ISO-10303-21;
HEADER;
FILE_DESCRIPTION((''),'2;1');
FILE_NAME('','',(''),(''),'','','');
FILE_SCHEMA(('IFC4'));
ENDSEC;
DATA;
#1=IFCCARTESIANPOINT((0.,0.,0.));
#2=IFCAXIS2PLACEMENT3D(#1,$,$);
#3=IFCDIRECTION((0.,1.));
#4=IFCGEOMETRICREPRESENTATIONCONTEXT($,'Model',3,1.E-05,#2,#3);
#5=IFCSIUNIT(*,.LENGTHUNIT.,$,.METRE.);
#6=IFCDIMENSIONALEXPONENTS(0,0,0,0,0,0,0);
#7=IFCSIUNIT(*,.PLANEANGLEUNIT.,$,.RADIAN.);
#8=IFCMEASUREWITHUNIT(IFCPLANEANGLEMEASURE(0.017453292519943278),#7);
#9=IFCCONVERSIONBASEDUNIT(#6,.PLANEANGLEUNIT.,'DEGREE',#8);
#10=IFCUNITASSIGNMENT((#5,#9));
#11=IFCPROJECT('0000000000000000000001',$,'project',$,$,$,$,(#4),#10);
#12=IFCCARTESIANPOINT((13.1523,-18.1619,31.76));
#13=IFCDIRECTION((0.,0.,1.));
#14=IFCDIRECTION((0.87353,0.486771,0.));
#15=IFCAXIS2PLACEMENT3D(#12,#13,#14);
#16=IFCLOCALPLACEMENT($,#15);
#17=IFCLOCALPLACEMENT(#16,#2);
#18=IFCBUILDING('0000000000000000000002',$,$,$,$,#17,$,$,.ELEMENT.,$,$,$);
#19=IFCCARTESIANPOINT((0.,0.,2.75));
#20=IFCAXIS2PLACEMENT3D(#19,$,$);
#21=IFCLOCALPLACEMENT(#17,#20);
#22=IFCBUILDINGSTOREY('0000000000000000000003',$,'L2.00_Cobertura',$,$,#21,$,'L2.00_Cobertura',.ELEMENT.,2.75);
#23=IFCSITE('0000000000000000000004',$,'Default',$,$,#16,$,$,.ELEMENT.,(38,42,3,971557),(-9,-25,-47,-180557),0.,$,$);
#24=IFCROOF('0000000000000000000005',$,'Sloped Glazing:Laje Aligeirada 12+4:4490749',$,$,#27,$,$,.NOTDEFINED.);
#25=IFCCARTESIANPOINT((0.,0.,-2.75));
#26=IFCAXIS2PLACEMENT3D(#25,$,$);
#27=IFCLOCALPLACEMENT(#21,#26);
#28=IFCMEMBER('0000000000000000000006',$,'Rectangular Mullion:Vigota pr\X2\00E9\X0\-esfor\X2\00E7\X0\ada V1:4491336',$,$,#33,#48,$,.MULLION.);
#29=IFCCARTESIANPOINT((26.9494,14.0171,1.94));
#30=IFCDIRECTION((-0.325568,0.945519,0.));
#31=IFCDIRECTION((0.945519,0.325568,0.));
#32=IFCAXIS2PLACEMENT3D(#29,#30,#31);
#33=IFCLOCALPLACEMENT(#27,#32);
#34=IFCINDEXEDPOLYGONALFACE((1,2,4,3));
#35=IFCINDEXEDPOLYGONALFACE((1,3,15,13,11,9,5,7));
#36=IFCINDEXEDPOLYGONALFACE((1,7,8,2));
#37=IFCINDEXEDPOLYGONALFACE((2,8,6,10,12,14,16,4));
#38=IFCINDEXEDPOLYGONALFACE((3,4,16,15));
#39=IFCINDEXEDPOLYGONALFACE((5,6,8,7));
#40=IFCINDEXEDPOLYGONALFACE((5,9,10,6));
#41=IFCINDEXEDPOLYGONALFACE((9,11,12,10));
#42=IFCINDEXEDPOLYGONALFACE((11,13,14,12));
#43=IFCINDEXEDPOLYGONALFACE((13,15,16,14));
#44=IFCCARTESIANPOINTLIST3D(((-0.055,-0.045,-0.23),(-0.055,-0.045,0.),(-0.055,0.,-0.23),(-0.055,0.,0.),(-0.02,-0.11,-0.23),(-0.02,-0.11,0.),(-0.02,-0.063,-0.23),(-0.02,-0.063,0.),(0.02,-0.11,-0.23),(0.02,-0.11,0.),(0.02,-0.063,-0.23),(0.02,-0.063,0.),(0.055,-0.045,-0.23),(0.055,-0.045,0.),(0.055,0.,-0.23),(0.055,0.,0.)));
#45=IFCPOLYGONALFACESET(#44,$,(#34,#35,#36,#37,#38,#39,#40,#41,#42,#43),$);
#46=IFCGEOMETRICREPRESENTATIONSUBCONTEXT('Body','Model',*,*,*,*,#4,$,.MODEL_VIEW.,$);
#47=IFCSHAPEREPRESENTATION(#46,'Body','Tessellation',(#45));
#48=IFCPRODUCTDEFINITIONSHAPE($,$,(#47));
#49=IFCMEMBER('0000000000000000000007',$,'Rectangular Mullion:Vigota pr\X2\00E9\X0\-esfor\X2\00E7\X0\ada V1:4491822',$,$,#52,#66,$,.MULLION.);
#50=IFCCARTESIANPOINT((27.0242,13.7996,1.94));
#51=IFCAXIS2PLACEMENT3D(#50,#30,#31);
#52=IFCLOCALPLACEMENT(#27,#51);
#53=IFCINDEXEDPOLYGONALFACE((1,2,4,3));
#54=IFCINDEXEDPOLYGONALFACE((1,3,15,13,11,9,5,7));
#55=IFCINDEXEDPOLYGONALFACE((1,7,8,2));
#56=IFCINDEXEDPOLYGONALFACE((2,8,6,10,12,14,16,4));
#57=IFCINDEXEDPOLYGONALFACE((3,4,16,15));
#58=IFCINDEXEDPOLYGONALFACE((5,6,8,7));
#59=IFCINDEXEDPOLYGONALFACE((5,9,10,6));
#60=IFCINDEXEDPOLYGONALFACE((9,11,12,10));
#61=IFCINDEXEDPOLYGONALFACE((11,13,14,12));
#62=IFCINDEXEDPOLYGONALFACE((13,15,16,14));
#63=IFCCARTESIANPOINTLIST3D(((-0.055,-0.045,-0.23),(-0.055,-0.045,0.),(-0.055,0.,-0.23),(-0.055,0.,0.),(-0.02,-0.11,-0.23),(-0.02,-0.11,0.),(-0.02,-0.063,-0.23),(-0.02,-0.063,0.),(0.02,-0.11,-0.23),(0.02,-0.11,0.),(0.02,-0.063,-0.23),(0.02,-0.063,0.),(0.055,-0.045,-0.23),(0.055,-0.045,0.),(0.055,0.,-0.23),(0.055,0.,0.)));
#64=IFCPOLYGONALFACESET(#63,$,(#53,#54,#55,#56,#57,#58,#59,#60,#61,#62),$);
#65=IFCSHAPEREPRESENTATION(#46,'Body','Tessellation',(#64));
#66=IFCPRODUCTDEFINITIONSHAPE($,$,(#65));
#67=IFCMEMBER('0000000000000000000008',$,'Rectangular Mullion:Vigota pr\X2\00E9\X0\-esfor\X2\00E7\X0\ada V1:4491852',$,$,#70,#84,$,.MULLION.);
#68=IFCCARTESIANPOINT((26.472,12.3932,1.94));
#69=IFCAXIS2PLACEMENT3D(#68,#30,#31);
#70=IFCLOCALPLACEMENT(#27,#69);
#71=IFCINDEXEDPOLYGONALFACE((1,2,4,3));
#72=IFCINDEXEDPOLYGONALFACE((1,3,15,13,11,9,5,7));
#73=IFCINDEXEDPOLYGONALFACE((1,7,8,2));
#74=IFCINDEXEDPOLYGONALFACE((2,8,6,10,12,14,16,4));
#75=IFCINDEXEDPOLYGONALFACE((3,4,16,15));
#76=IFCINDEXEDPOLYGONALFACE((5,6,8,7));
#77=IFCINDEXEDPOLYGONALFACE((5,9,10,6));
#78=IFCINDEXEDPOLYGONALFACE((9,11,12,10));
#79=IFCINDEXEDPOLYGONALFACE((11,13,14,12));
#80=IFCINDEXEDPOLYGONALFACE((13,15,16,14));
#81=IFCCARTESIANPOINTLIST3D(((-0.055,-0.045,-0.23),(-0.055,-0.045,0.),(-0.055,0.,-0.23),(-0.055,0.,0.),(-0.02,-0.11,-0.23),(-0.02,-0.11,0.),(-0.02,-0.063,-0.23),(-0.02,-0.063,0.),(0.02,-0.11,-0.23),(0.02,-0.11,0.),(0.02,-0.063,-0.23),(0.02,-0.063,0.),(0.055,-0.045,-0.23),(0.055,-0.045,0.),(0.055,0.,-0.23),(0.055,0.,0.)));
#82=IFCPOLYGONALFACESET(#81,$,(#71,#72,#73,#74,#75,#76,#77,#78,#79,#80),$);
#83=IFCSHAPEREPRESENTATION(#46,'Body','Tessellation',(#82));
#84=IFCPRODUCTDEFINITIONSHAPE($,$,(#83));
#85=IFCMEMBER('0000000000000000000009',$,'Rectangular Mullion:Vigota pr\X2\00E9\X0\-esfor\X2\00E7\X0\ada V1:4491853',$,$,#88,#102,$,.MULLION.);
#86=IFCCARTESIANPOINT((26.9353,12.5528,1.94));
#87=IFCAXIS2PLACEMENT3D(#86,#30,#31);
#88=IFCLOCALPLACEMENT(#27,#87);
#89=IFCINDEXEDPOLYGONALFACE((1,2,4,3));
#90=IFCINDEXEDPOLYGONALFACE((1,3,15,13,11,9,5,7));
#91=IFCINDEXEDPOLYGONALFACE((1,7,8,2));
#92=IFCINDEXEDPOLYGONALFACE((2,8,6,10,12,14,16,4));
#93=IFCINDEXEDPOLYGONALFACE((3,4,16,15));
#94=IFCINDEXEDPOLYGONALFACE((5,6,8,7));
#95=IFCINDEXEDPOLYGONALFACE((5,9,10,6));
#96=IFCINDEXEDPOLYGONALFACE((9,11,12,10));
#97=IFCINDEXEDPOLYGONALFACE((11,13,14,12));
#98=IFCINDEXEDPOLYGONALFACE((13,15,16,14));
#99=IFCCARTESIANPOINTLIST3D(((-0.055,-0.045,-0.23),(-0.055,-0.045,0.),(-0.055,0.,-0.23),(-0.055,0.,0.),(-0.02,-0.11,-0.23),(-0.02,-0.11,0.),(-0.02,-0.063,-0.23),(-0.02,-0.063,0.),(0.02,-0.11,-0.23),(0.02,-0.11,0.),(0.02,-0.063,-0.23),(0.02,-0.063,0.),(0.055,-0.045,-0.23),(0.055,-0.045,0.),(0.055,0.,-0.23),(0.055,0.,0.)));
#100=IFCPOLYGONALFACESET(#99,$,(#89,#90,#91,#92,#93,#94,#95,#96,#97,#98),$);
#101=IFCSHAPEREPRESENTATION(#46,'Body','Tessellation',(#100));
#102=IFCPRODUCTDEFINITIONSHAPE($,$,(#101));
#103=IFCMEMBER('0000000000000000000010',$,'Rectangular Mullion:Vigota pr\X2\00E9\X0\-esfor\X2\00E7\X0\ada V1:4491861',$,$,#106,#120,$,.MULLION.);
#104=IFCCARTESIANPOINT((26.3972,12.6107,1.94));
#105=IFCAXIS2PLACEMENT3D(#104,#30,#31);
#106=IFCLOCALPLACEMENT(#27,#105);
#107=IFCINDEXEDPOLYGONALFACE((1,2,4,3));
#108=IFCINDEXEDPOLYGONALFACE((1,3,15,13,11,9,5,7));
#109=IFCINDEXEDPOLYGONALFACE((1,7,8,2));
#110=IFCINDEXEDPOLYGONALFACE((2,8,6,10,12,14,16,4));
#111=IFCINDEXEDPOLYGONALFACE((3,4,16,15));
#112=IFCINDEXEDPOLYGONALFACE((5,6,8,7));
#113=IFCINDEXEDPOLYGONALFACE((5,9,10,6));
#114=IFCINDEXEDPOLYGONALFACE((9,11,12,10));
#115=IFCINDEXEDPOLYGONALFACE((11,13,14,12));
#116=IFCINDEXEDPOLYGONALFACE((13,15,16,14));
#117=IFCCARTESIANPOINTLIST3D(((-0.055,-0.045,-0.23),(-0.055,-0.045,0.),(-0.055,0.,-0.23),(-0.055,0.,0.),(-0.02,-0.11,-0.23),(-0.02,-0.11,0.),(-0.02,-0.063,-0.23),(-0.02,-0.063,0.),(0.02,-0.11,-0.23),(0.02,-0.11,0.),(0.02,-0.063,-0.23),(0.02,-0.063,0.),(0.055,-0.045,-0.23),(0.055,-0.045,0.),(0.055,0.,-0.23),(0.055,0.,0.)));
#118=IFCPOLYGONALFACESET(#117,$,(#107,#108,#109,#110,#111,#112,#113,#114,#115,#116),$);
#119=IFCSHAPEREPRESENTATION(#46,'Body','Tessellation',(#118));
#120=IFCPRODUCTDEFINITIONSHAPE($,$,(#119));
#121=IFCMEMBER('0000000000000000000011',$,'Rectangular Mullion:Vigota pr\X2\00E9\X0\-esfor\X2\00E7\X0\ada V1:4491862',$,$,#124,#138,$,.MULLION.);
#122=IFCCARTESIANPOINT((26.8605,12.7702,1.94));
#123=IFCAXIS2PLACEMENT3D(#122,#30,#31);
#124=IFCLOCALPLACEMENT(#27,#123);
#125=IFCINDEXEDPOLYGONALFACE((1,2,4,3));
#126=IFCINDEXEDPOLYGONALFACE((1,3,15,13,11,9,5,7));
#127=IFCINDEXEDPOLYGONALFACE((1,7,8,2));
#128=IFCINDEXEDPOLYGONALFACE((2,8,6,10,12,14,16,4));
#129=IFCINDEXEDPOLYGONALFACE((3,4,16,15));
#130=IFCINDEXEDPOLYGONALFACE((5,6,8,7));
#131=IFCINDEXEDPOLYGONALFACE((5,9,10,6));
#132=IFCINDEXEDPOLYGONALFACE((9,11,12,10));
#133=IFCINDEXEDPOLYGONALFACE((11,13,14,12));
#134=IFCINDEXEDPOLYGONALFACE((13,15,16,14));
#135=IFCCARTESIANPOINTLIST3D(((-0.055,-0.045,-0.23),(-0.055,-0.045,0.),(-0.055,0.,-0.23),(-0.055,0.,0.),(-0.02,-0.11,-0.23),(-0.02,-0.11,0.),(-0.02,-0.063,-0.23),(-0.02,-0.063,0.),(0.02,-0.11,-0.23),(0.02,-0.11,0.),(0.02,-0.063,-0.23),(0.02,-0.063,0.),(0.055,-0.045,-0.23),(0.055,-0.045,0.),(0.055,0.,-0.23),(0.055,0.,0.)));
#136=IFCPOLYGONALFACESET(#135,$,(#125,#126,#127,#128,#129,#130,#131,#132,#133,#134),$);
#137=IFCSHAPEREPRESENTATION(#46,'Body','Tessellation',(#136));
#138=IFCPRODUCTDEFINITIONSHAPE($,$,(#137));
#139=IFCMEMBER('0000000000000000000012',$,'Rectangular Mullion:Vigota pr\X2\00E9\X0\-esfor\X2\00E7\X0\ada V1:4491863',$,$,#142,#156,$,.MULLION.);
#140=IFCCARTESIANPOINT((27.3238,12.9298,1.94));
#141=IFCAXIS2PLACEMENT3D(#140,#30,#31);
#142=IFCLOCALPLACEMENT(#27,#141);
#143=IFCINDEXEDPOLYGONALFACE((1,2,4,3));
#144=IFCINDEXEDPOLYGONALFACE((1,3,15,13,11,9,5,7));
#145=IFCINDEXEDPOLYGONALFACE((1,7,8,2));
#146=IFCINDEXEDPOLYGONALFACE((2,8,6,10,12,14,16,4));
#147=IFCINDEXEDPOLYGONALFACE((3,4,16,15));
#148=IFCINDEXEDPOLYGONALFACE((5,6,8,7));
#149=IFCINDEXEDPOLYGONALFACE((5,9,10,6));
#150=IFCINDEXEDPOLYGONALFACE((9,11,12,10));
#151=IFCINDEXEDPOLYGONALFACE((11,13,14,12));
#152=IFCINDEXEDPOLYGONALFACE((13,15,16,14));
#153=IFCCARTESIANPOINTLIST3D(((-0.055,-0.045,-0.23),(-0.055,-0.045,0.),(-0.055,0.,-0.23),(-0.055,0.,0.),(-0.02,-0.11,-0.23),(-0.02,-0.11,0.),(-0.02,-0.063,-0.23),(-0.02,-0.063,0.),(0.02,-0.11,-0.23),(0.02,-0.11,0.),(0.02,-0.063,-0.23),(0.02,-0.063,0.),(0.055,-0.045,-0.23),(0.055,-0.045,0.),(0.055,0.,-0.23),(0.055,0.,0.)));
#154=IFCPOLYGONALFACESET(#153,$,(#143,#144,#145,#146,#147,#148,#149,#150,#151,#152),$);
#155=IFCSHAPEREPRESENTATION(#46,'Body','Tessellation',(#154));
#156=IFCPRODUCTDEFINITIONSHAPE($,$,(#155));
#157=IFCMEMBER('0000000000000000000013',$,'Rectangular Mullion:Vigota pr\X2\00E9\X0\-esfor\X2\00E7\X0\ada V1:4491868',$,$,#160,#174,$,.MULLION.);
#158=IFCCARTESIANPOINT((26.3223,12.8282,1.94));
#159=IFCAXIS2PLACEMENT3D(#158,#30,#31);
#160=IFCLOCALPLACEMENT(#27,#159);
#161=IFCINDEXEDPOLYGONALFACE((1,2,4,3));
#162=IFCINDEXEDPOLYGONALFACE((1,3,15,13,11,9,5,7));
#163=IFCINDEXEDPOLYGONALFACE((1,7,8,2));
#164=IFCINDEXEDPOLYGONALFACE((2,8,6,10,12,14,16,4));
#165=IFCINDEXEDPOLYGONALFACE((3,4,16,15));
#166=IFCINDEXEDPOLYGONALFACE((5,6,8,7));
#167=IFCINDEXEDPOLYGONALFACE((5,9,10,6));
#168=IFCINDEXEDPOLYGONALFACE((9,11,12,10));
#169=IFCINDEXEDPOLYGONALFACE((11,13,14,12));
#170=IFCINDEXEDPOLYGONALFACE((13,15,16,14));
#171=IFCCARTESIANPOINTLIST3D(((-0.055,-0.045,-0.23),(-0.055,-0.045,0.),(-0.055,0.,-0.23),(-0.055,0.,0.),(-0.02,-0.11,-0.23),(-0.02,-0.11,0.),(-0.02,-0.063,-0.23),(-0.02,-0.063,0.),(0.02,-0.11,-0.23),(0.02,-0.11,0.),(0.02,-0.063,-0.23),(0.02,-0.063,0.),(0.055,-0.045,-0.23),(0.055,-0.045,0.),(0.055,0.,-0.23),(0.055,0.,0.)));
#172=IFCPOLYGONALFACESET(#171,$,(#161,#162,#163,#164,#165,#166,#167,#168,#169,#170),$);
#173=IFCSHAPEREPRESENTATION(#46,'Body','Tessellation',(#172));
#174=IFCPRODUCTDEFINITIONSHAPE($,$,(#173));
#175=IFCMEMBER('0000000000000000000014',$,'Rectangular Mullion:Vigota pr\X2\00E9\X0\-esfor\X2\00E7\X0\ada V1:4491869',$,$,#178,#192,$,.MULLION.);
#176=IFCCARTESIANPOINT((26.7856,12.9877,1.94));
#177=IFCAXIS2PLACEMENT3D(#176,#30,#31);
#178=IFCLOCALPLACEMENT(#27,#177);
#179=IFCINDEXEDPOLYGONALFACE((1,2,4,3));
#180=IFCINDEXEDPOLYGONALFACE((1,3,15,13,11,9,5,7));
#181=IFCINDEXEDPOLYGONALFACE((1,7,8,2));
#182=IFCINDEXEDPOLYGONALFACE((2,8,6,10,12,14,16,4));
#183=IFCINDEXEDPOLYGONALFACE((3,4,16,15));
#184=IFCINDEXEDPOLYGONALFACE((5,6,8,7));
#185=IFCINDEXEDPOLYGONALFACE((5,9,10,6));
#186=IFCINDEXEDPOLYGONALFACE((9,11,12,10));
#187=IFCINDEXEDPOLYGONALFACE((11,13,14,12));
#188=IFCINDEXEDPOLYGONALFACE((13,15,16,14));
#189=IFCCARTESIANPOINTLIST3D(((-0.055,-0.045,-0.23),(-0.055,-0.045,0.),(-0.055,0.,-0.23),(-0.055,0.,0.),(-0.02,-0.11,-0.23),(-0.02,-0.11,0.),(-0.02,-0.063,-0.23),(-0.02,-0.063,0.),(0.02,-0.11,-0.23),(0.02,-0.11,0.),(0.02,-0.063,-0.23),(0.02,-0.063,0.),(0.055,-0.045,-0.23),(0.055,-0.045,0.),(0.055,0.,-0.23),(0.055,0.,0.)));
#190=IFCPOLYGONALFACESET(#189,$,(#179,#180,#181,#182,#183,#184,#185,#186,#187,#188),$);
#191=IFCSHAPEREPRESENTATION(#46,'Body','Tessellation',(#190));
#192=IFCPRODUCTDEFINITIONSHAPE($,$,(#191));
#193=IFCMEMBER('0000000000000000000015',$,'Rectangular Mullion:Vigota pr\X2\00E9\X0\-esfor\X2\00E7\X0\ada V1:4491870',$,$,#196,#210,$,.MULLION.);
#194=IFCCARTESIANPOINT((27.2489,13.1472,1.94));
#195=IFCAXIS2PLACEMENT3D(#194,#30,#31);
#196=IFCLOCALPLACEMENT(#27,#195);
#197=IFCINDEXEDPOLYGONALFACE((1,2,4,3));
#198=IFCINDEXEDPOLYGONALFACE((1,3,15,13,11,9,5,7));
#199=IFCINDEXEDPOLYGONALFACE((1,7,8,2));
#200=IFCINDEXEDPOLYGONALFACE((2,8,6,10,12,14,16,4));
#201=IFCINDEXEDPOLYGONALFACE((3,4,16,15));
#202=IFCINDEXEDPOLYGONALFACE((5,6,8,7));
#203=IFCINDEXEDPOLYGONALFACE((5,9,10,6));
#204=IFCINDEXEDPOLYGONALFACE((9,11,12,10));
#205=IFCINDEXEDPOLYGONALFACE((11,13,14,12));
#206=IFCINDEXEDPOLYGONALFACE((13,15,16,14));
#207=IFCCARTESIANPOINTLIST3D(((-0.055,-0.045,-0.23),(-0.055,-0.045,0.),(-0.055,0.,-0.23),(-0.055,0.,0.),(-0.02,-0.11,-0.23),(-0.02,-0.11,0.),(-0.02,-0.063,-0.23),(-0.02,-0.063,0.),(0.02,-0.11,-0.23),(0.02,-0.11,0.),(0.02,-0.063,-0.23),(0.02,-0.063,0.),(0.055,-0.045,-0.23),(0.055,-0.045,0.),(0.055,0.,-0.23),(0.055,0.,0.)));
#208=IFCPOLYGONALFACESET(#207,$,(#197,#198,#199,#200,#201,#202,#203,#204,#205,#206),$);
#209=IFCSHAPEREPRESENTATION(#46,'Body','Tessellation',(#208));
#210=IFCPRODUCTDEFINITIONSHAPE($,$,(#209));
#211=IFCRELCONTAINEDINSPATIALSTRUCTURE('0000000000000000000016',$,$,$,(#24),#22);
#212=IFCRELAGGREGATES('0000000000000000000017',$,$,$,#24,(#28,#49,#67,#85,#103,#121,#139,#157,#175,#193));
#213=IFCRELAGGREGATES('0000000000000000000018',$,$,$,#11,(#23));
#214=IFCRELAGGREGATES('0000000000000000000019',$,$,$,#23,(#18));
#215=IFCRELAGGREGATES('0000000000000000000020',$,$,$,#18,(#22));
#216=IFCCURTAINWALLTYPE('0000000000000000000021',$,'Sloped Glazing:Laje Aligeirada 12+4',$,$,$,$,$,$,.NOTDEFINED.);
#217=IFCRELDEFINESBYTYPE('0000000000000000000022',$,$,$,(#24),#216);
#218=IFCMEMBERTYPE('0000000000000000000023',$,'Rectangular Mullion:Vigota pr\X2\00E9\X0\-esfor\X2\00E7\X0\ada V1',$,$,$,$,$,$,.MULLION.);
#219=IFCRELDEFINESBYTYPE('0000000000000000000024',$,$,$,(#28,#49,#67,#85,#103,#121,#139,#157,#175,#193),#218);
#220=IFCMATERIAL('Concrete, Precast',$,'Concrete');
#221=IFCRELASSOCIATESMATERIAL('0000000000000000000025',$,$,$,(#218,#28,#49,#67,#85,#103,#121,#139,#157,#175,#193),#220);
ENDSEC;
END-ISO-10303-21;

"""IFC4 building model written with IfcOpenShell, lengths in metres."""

from ifc_helpers import new_model, entity, si_unit, converted_unit, direction, frame, origin, place, context, subcontext, project, spatial, indexed_curve, outline, extrude, source, transform, mapped, material, type_object, type_shapes, element, aggregate, save


model = new_model("IFC4")

# Units and contexts
model_context = context("Model", 3, precision=1e-05, world=origin(), true_north=direction((0.0, 1.0)))
body_context = subcontext(model_context, "Body", "Model", "MODEL_VIEW")
ifc_project = project(units=[si_unit("LENGTHUNIT", "METRE"), converted_unit("PLANEANGLEUNIT", "DEGREE", entity("IfcPlaneAngleMeasure", 0.017453292519943278), si_unit("PLANEANGLEUNIT", "RADIAN"), dimensions=[0, 0, 0, 0, 0, 0, 0])], contexts=[model_context])

# Site, building, storey
site_placement = place(None, frame((13.1523, -18.1619, 31.76), z_axis=(0.0, 0.0, 1.0), x_axis=(0.87353, 0.486771, 0.0)))
site = spatial("IfcSite", under=ifc_project, at=site_placement, Name="Default", CompositionType="ELEMENT", RefLatitude=(38, 42, 3, 971557), RefLongitude=(-9, -25, -47, -180557), RefElevation=0.0)
building_placement = place(site_placement, origin())
building = spatial("IfcBuilding", under=site, at=building_placement, CompositionType="ELEMENT")
storey_placement = place(building_placement, frame((0.0, 0.0, 2.75)))
storey = spatial("IfcBuildingStorey", under=building, at=storey_placement, Name="L2.00_Cobertura", LongName="L2.00_Cobertura", CompositionType="ELEMENT", Elevation=2.75)

# Roof, members
curtain_wall_type = type_object("IfcCurtainWallType", Name="Sloped Glazing:Laje Aligeirada 12+4", PredefinedType="NOTDEFINED")
roof_placement = place(storey_placement, frame((0.0, 0.0, -2.75)))
roof = element("IfcRoof", 1, at=roof_placement, inside=storey, type_object=curtain_wall_type, Name="Sloped Glazing:Laje Aligeirada 12+4:4490749", PredefinedType="NOTDEFINED")
ifc_material_1 = material(Name="Concrete, Precast", Category="Concrete")
member_type = type_object("IfcMemberType", Name="Rectangular Mullion:Vigota pré-esforçada V1", PredefinedType="MULLION", material=ifc_material_1)
shared_shape_1 = source(origin(), body_context, "Body", "SweptSolid", [
    extrude(outline(indexed_curve([(-0.055, -0.0545), (0.055, -0.0545), (0.055, -0.0095), (0.02, 0.0085), (0.02, 0.0555), (-0.02, 0.0555), (-0.02, 0.0085), (-0.055, -0.0095), (-0.055, -0.0545)], self_intersect=False)), frame((0.0, -0.0545, -0.23), z_axis=(0.0, 0.0, 1.0), x_axis=(-1.0, 0.0, 0.0)), (0.0, 0.0, 1.0), 0.23),
])
type_shapes(member_type, [shared_shape_1])
member_1_placement = place(roof_placement, frame((26.9494, 14.0171, 1.94), z_axis=(-0.325568, 0.945519, 0.0), x_axis=(0.945519, 0.325568, 0.0)))
member_1 = element("IfcMember", 2, at=member_1_placement, type_object=member_type, material=ifc_material_1, Name="Rectangular Mullion:Vigota pré-esforçada V1:4491336", PredefinedType="MULLION", context=body_context, shape_type="MappedRepresentation", body=[
    mapped(shared_shape_1, transform((0.0, 0.0, 0.0), scale=1.0)),
])
member_2_placement = place(roof_placement, frame((27.0242, 13.7996, 1.94), z_axis=(-0.325568, 0.945519, 0.0), x_axis=(0.945519, 0.325568, 0.0)))
member_2 = element("IfcMember", 3, at=member_2_placement, type_object=member_type, material=ifc_material_1, Name="Rectangular Mullion:Vigota pré-esforçada V1:4491822", PredefinedType="MULLION", context=body_context, shape_type="MappedRepresentation", body=[
    mapped(shared_shape_1, transform((0.0, 0.0, 0.0), scale=1.0)),
])
member_3_placement = place(roof_placement, frame((26.472, 12.3932, 1.94), z_axis=(-0.325568, 0.945519, 0.0), x_axis=(0.945519, 0.325568, 0.0)))
member_3 = element("IfcMember", 4, at=member_3_placement, type_object=member_type, material=ifc_material_1, Name="Rectangular Mullion:Vigota pré-esforçada V1:4491852", PredefinedType="MULLION", context=body_context, shape_type="MappedRepresentation", body=[
    mapped(shared_shape_1, transform((0.0, 0.0, 0.0), scale=1.0)),
])
member_4_placement = place(roof_placement, frame((26.9353, 12.5528, 1.94), z_axis=(-0.325568, 0.945519, 0.0), x_axis=(0.945519, 0.325568, 0.0)))
member_4 = element("IfcMember", 5, at=member_4_placement, type_object=member_type, material=ifc_material_1, Name="Rectangular Mullion:Vigota pré-esforçada V1:4491853", PredefinedType="MULLION", context=body_context, shape_type="MappedRepresentation", body=[
    mapped(shared_shape_1, transform((0.0, 0.0, 0.0), scale=1.0)),
])
member_5_placement = place(roof_placement, frame((26.3972, 12.6107, 1.94), z_axis=(-0.325568, 0.945519, 0.0), x_axis=(0.945519, 0.325568, 0.0)))
member_5 = element("IfcMember", 6, at=member_5_placement, type_object=member_type, material=ifc_material_1, Name="Rectangular Mullion:Vigota pré-esforçada V1:4491861", PredefinedType="MULLION", context=body_context, shape_type="MappedRepresentation", body=[
    mapped(shared_shape_1, transform((0.0, 0.0, 0.0), scale=1.0)),
])
member_6_placement = place(roof_placement, frame((26.8605, 12.7702, 1.94), z_axis=(-0.325568, 0.945519, 0.0), x_axis=(0.945519, 0.325568, 0.0)))
member_6 = element("IfcMember", 7, at=member_6_placement, type_object=member_type, material=ifc_material_1, Name="Rectangular Mullion:Vigota pré-esforçada V1:4491862", PredefinedType="MULLION", context=body_context, shape_type="MappedRepresentation", body=[
    mapped(shared_shape_1, transform((0.0, 0.0, 0.0), scale=1.0)),
])
member_7_placement = place(roof_placement, frame((27.3238, 12.9298, 1.94), z_axis=(-0.325568, 0.945519, 0.0), x_axis=(0.945519, 0.325568, 0.0)))
member_7 = element("IfcMember", 8, at=member_7_placement, type_object=member_type, material=ifc_material_1, Name="Rectangular Mullion:Vigota pré-esforçada V1:4491863", PredefinedType="MULLION", context=body_context, shape_type="MappedRepresentation", body=[
    mapped(shared_shape_1, transform((0.0, 0.0, 0.0), scale=1.0)),
])
member_8_placement = place(roof_placement, frame((26.3223, 12.8282, 1.94), z_axis=(-0.325568, 0.945519, 0.0), x_axis=(0.945519, 0.325568, 0.0)))
member_8 = element("IfcMember", 9, at=member_8_placement, type_object=member_type, material=ifc_material_1, Name="Rectangular Mullion:Vigota pré-esforçada V1:4491868", PredefinedType="MULLION", context=body_context, shape_type="MappedRepresentation", body=[
    mapped(shared_shape_1, transform((0.0, 0.0, 0.0), scale=1.0)),
])
member_9_placement = place(roof_placement, frame((26.7856, 12.9877, 1.94), z_axis=(-0.325568, 0.945519, 0.0), x_axis=(0.945519, 0.325568, 0.0)))
member_9 = element("IfcMember", 10, at=member_9_placement, type_object=member_type, material=ifc_material_1, Name="Rectangular Mullion:Vigota pré-esforçada V1:4491869", PredefinedType="MULLION", context=body_context, shape_type="MappedRepresentation", body=[
    mapped(shared_shape_1, transform((0.0, 0.0, 0.0), scale=1.0)),
])
member_10_placement = place(roof_placement, frame((27.2489, 13.1472, 1.94), z_axis=(-0.325568, 0.945519, 0.0), x_axis=(0.945519, 0.325568, 0.0)))
member_10 = element("IfcMember", 11, at=member_10_placement, type_object=member_type, material=ifc_material_1, Name="Rectangular Mullion:Vigota pré-esforçada V1:4491870", PredefinedType="MULLION", context=body_context, shape_type="MappedRepresentation", body=[
    mapped(shared_shape_1, transform((0.0, 0.0, 0.0), scale=1.0)),
])
aggregate(roof, [member_1, member_2, member_3, member_4, member_5, member_6, member_7, member_8, member_9, member_10])

save(model, "model.ifc")
